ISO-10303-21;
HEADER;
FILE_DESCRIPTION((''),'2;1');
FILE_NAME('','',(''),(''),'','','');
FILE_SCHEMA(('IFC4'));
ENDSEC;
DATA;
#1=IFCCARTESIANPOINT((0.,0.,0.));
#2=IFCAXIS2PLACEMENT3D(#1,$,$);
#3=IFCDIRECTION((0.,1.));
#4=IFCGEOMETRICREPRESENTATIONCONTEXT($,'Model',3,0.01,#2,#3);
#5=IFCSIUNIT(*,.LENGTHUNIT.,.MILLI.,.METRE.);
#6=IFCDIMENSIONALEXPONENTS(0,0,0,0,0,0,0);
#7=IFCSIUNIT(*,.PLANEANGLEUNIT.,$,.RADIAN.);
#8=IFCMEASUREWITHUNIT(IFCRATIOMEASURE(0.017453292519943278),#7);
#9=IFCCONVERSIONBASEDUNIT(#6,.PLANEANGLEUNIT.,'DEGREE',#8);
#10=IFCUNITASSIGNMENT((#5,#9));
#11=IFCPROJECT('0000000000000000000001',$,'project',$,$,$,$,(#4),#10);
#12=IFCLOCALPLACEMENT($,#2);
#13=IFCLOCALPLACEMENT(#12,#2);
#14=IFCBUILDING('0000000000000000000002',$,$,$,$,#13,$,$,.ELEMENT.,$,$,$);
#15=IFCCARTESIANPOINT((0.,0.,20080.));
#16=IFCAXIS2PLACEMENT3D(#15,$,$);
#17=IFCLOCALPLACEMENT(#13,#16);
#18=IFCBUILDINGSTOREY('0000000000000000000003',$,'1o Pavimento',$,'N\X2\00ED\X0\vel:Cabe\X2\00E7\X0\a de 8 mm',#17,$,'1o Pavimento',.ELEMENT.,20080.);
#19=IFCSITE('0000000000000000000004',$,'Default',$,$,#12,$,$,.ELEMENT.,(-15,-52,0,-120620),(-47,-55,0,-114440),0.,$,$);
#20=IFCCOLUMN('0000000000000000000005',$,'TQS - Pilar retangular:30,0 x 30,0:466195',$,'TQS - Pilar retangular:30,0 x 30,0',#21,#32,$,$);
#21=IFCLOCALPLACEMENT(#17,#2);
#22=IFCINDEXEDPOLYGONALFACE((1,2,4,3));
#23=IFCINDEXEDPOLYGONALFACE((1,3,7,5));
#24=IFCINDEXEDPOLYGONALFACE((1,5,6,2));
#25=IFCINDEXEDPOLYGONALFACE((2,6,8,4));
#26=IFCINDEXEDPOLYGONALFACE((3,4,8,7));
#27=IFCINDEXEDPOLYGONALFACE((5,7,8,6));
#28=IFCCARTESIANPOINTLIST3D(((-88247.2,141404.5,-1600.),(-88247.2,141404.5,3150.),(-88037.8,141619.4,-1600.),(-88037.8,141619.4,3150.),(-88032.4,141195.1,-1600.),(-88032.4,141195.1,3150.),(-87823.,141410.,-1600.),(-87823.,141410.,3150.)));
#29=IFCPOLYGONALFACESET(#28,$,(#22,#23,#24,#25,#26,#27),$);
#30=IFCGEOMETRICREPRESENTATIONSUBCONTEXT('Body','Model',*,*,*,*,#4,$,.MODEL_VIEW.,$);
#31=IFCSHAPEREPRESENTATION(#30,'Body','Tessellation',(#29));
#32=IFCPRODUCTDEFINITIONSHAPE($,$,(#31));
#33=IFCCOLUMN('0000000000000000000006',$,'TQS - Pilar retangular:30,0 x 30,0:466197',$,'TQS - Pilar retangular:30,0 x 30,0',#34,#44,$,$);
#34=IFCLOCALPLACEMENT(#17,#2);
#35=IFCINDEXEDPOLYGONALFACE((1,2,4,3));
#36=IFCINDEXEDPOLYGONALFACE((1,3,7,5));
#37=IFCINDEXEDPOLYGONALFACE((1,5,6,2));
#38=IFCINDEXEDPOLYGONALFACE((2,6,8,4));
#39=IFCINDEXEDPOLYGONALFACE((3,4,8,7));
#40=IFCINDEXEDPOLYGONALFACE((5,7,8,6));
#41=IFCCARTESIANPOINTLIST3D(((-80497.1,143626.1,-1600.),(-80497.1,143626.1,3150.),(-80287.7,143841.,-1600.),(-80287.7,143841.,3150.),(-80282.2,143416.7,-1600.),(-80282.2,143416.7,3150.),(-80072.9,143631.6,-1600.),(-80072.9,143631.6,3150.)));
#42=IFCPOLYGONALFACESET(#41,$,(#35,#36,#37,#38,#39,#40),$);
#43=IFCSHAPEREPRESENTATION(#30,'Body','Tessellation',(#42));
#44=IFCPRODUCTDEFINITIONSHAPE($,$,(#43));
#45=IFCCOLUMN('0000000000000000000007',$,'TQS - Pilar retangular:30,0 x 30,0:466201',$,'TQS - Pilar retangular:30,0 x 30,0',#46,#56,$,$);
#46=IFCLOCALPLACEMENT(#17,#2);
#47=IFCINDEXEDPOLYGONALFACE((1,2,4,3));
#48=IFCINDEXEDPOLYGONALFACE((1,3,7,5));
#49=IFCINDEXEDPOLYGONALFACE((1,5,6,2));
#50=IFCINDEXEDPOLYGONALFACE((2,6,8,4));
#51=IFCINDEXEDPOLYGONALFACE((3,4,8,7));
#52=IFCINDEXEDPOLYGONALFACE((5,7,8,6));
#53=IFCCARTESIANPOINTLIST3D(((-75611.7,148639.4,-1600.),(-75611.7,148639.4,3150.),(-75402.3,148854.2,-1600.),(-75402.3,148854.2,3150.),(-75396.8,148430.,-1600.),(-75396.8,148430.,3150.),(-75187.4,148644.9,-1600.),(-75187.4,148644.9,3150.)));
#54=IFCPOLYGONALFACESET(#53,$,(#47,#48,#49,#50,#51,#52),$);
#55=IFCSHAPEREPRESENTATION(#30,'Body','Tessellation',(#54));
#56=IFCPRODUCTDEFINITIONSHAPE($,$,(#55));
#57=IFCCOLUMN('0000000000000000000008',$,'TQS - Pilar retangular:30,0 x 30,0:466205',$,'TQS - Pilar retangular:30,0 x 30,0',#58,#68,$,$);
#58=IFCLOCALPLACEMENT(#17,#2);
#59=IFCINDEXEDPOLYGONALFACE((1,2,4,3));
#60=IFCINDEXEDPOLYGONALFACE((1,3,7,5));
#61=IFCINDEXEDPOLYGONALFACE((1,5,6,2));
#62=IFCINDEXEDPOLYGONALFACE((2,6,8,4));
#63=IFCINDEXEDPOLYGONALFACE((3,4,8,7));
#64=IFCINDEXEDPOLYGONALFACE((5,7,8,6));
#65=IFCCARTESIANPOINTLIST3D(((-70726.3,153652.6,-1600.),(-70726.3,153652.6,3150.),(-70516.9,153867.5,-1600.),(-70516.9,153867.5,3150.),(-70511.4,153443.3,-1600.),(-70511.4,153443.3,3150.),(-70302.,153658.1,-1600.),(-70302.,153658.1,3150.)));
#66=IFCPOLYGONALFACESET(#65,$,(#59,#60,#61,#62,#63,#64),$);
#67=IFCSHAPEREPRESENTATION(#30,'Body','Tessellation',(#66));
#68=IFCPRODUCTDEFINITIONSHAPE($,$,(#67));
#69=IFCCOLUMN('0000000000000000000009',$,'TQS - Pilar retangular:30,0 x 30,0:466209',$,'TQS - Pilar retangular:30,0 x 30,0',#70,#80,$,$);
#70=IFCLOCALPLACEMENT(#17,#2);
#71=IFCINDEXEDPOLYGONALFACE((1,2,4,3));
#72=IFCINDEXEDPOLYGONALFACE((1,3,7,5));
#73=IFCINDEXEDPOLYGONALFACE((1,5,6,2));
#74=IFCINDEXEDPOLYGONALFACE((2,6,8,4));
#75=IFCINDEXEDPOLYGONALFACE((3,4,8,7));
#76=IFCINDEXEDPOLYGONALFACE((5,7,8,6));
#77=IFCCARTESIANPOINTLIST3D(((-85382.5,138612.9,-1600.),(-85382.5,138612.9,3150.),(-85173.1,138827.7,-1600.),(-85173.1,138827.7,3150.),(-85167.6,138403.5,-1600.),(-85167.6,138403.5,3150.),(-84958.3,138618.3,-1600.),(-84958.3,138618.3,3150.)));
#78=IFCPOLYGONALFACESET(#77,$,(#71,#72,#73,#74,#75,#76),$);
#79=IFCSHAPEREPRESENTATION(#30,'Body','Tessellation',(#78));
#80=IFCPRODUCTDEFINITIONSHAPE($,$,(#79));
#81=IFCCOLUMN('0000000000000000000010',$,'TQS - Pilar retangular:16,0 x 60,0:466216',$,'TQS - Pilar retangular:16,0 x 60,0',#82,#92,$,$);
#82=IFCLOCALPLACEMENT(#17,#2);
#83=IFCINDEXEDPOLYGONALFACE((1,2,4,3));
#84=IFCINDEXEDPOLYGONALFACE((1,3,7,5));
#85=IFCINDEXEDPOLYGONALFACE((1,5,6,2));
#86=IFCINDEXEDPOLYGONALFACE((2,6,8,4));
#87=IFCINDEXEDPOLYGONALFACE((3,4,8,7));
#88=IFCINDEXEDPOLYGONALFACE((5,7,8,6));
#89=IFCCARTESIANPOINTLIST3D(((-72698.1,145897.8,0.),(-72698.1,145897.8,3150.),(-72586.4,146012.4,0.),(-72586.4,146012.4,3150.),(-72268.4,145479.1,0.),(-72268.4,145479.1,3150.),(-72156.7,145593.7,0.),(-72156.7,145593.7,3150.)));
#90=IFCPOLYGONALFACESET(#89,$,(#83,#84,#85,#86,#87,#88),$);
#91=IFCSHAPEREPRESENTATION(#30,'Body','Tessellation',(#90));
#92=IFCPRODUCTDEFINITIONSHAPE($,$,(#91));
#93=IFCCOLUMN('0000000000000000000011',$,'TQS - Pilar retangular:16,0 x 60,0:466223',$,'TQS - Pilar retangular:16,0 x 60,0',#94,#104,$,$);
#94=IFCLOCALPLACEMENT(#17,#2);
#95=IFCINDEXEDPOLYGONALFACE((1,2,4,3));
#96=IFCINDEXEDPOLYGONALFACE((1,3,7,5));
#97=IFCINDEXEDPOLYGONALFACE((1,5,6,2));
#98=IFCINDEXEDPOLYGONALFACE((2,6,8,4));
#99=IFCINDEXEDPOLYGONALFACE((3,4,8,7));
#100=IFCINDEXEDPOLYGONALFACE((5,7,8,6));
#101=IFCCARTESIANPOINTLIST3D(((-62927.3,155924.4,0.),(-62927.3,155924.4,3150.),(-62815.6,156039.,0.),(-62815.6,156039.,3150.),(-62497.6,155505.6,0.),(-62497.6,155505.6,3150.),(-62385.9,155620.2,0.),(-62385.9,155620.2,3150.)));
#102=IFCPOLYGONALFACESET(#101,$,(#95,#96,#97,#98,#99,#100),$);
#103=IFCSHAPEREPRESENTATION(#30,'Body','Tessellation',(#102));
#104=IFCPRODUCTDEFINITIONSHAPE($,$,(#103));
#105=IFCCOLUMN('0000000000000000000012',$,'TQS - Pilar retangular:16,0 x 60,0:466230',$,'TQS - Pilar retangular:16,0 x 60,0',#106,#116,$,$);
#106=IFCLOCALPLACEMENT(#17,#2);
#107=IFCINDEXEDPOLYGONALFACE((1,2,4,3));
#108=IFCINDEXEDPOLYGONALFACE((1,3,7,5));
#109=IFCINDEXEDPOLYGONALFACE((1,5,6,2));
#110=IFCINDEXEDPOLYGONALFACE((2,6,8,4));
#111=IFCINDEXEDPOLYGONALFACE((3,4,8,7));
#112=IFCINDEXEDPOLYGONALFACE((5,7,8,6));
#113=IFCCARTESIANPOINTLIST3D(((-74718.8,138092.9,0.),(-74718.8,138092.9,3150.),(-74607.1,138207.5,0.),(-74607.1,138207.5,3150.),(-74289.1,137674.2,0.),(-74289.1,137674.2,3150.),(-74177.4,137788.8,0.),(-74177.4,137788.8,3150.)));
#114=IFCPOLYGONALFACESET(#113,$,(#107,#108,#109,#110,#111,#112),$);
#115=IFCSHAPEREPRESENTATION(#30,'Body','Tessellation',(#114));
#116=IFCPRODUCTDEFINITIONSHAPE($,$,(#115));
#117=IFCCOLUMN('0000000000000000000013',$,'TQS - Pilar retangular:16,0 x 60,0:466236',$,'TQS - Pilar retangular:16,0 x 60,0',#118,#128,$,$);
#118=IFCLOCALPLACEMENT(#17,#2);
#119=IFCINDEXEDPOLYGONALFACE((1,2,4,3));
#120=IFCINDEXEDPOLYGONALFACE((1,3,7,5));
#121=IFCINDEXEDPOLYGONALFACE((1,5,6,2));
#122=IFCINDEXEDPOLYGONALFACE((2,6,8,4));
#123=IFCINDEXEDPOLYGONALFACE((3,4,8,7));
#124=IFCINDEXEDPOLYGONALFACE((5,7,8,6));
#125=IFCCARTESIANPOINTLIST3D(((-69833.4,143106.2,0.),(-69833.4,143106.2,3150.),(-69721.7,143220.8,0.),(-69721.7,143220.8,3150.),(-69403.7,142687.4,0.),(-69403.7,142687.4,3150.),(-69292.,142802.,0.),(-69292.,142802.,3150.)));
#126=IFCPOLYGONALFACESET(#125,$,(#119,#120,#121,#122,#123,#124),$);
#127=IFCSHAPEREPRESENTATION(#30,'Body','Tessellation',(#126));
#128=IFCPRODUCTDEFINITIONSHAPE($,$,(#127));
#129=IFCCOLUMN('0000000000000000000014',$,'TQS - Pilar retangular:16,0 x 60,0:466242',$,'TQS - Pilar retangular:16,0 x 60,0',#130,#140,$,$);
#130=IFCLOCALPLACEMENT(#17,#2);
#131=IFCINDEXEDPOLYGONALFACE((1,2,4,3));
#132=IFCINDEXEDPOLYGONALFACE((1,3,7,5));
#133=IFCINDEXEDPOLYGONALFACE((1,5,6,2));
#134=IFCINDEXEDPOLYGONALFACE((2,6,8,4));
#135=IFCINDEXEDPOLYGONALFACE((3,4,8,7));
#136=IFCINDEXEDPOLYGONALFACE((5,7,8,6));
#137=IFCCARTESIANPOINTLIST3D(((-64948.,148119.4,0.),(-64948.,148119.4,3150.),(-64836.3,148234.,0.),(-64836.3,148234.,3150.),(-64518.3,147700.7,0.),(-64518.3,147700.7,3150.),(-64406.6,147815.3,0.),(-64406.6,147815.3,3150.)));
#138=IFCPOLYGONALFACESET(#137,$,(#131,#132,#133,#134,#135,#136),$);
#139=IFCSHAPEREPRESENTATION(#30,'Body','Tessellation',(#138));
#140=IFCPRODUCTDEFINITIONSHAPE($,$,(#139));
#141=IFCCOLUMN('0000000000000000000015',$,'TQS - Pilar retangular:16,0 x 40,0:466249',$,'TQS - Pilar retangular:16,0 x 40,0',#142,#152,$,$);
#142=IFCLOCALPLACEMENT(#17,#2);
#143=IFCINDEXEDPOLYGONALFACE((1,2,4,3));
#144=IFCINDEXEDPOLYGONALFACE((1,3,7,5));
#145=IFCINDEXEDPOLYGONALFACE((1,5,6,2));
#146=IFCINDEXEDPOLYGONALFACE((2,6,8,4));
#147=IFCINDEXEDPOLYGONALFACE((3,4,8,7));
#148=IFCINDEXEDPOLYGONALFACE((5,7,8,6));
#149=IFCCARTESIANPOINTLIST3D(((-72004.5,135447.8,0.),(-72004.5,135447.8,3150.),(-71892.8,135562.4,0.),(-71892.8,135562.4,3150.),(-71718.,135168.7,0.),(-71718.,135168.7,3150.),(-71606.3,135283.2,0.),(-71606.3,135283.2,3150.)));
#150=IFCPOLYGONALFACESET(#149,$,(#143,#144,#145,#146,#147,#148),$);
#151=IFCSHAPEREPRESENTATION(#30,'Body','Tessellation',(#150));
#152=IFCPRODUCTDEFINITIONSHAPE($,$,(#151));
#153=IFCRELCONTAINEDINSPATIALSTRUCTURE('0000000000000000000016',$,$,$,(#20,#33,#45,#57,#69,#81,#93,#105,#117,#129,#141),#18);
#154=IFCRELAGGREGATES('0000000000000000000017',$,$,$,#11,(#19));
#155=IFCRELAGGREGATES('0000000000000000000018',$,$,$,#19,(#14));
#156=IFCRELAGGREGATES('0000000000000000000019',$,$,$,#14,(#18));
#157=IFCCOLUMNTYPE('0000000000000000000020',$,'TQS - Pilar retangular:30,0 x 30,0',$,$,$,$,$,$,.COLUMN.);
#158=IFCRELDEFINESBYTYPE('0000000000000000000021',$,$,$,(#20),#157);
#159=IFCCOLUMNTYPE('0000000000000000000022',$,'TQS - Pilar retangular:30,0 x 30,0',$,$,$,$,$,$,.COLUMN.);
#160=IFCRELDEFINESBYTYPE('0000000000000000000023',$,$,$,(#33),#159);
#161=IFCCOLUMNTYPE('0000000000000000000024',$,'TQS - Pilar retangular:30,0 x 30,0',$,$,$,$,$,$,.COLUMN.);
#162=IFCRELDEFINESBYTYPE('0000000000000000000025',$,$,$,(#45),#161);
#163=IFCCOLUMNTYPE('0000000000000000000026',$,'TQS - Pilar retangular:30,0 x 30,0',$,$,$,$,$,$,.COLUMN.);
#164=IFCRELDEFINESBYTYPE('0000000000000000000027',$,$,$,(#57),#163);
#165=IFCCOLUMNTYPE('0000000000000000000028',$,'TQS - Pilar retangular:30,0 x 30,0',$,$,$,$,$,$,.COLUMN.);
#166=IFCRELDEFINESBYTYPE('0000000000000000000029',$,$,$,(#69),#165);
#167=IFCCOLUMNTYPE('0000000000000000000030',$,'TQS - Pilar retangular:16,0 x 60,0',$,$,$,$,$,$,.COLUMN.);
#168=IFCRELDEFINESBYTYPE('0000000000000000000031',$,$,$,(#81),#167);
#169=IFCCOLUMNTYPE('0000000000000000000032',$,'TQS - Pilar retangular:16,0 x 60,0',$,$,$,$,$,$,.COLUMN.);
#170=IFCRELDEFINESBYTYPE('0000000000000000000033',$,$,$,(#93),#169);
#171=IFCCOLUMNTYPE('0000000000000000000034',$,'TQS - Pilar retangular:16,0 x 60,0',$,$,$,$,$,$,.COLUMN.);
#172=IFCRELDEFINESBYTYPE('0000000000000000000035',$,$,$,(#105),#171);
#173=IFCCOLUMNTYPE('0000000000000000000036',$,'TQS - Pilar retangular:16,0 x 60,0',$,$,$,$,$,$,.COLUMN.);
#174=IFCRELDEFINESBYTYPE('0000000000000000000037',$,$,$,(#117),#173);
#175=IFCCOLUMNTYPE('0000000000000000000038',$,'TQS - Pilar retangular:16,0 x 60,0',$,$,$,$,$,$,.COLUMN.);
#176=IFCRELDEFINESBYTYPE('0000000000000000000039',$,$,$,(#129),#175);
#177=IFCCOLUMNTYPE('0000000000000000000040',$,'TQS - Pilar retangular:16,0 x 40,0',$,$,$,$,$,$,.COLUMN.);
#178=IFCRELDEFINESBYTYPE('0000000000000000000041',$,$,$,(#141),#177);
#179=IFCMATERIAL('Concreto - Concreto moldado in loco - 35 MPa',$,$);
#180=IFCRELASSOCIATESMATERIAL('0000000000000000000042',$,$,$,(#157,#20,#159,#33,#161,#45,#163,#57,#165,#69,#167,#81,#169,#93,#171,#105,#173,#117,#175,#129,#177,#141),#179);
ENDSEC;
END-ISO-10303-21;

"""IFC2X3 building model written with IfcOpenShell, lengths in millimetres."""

from ifc_helpers import new_model, entity, si_unit, converted_unit, direction, frame, frame_2d, origin, origin_2d_with_axis, place, context, subcontext, project, spatial, rectangle, extrude, source, transform, mapped, material, type_object, type_shapes, element, save


model = new_model("IFC2X3")

# Units and contexts
model_context = context("Model", 3, precision=0.01, world=origin(), true_north=direction((0.0, 1.0)))
body_context = subcontext(model_context, "Body", "Model", "MODEL_VIEW")
ifc_project = project(units=[si_unit("LENGTHUNIT", "METRE", prefix="MILLI"), converted_unit("PLANEANGLEUNIT", "DEGREE", entity("IfcRatioMeasure", 0.017453292519943278), si_unit("PLANEANGLEUNIT", "RADIAN"), dimensions=[0, 0, 0, 0, 0, 0, 0])], contexts=[model_context])

# Site, building, storey
site_placement = place(None, origin())
site = spatial("IfcSite", under=ifc_project, at=site_placement, Name="Default", CompositionType="ELEMENT", RefLatitude=(-15, -52, 0, -120620), RefLongitude=(-47, -55, 0, -114440), RefElevation=0.0)
building_placement = place(site_placement, origin())
building = spatial("IfcBuilding", under=site, at=building_placement, CompositionType="ELEMENT")
storey_placement = place(building_placement, frame((0.0, 0.0, 20080.0)))
storey = spatial("IfcBuildingStorey", under=building, at=storey_placement, Name="1o Pavimento", ObjectType="Nível:Cabeça de 8 mm", LongName="1o Pavimento", CompositionType="ELEMENT", Elevation=20080.0)

# Columns
ifc_material = material(Name="Concreto - Concreto moldado in loco - 35 MPa")
column_type_1 = type_object("IfcColumnType", Name="TQS - Pilar retangular:30,0 x 30,0", PredefinedType="COLUMN", material=ifc_material)
shared_shape_1 = source(origin(), body_context, "Body", "SweptSolid", [
    extrude(rectangle(XDim=300.0, YDim=300.0, at=origin_2d_with_axis()), frame((-88035.1, 141407.3, 18480.0), z_axis=(0.0, 0.0, 1.0), x_axis=(-0.71618, 0.697915, 0.0)), (0.0, 0.0, 1.0), 4750.0),
])
type_shapes(column_type_1, [shared_shape_1])
column_1_placement = place(storey_placement, frame((0.0, 0.0, -20080.0)))
element("IfcColumn", 1, at=column_1_placement, inside=storey, type_object=column_type_1, material=ifc_material, Name="TQS - Pilar retangular:30,0 x 30,0:466195", ObjectType="TQS - Pilar retangular:30,0 x 30,0", context=body_context, shape_type="MappedRepresentation", body=[
    mapped(shared_shape_1, transform((0.0, 0.0, 0.0), scale=1.0)),
])
column_type_2 = type_object("IfcColumnType", Name="TQS - Pilar retangular:30,0 x 30,0", PredefinedType="COLUMN", material=ifc_material)
shared_shape_2 = source(origin(), body_context, "Body", "SweptSolid", [
    extrude(rectangle(XDim=300.0, YDim=300.0, at=origin_2d_with_axis()), frame((-80285.0, 143628.9, 18480.0), z_axis=(0.0, 0.0, 1.0), x_axis=(-0.71618, 0.697915, 0.0)), (0.0, 0.0, 1.0), 4750.0),
])
type_shapes(column_type_2, [shared_shape_2])
column_2_placement = place(storey_placement, frame((0.0, 0.0, -20080.0)))
element("IfcColumn", 2, at=column_2_placement, inside=storey, type_object=column_type_2, material=ifc_material, Name="TQS - Pilar retangular:30,0 x 30,0:466197", ObjectType="TQS - Pilar retangular:30,0 x 30,0", context=body_context, shape_type="MappedRepresentation", body=[
    mapped(shared_shape_2, transform((0.0, 0.0, 0.0), scale=1.0)),
])
column_type_3 = type_object("IfcColumnType", Name="TQS - Pilar retangular:30,0 x 30,0", PredefinedType="COLUMN", material=ifc_material)
shared_shape_3 = source(origin(), body_context, "Body", "SweptSolid", [
    extrude(rectangle(XDim=300.0, YDim=300.0, at=origin_2d_with_axis()), frame((-75399.6, 148642.1, 18480.0), z_axis=(0.0, 0.0, 1.0), x_axis=(-0.71618, 0.697915, 0.0)), (0.0, 0.0, 1.0), 4750.0),
])
type_shapes(column_type_3, [shared_shape_3])
column_3_placement = place(storey_placement, frame((0.0, 0.0, -20080.0)))
element("IfcColumn", 3, at=column_3_placement, inside=storey, type_object=column_type_3, material=ifc_material, Name="TQS - Pilar retangular:30,0 x 30,0:466201", ObjectType="TQS - Pilar retangular:30,0 x 30,0", context=body_context, shape_type="MappedRepresentation", body=[
    mapped(shared_shape_3, transform((0.0, 0.0, 0.0), scale=1.0)),
])
column_type_4 = type_object("IfcColumnType", Name="TQS - Pilar retangular:30,0 x 30,0", PredefinedType="COLUMN", material=ifc_material)
shared_shape_4 = source(origin(), body_context, "Body", "SweptSolid", [
    extrude(rectangle(XDim=300.0, YDim=300.0, at=origin_2d_with_axis()), frame((-70514.2, 153655.4, 18480.0), z_axis=(0.0, 0.0, 1.0), x_axis=(-0.71618, 0.697915, 0.0)), (0.0, 0.0, 1.0), 4750.0),
])
type_shapes(column_type_4, [shared_shape_4])
column_4_placement = place(storey_placement, frame((0.0, 0.0, -20080.0)))
element("IfcColumn", 4, at=column_4_placement, inside=storey, type_object=column_type_4, material=ifc_material, Name="TQS - Pilar retangular:30,0 x 30,0:466205", ObjectType="TQS - Pilar retangular:30,0 x 30,0", context=body_context, shape_type="MappedRepresentation", body=[
    mapped(shared_shape_4, transform((0.0, 0.0, 0.0), scale=1.0)),
])
column_type_5 = type_object("IfcColumnType", Name="TQS - Pilar retangular:30,0 x 30,0", PredefinedType="COLUMN", material=ifc_material)
shared_shape_5 = source(origin(), body_context, "Body", "SweptSolid", [
    extrude(rectangle(XDim=300.0, YDim=300.0, at=origin_2d_with_axis()), frame((-85170.4, 138615.6, 18480.0), z_axis=(0.0, 0.0, 1.0), x_axis=(-0.71618, 0.697915, 0.0)), (0.0, 0.0, 1.0), 4750.0),
])
type_shapes(column_type_5, [shared_shape_5])
column_5_placement = place(storey_placement, frame((0.0, 0.0, -20080.0)))
element("IfcColumn", 5, at=column_5_placement, inside=storey, type_object=column_type_5, material=ifc_material, Name="TQS - Pilar retangular:30,0 x 30,0:466209", ObjectType="TQS - Pilar retangular:30,0 x 30,0", context=body_context, shape_type="MappedRepresentation", body=[
    mapped(shared_shape_5, transform((0.0, 0.0, 0.0), scale=1.0)),
])
column_type_6 = type_object("IfcColumnType", Name="TQS - Pilar retangular:16,0 x 60,0", PredefinedType="COLUMN", material=ifc_material)
shared_shape_6 = source(origin(), body_context, "Body", "SweptSolid", [
    extrude(rectangle(XDim=600.0, YDim=160.0, at=frame_2d((0.0, 0.0), x_axis=(1.0, 0.0))), frame((-72427.4, 145745.8, 20080.0), z_axis=(0.0, 0.0, 1.0), x_axis=(-0.71618, 0.697915, 0.0)), (0.0, 0.0, 1.0), 3150.0),
])
type_shapes(column_type_6, [shared_shape_6])
column_6_placement = place(storey_placement, frame((0.0, 0.0, -20080.0)))
element("IfcColumn", 6, at=column_6_placement, inside=storey, type_object=column_type_6, material=ifc_material, Name="TQS - Pilar retangular:16,0 x 60,0:466216", ObjectType="TQS - Pilar retangular:16,0 x 60,0", context=body_context, shape_type="MappedRepresentation", body=[
    mapped(shared_shape_6, transform((0.0, 0.0, 0.0), scale=1.0)),
])
column_type_7 = type_object("IfcColumnType", Name="TQS - Pilar retangular:16,0 x 60,0", PredefinedType="COLUMN", material=ifc_material)
shared_shape_7 = source(origin(), body_context, "Body", "SweptSolid", [
    extrude(rectangle(XDim=600.0, YDim=160.0, at=frame_2d((0.0, 0.0), x_axis=(1.0, 0.0))), frame((-62656.6, 155772.3, 20080.0), z_axis=(0.0, 0.0, 1.0), x_axis=(-0.71618, 0.697915, 0.0)), (0.0, 0.0, 1.0), 3150.0),
])
type_shapes(column_type_7, [shared_shape_7])
column_7_placement = place(storey_placement, frame((0.0, 0.0, -20080.0)))
element("IfcColumn", 7, at=column_7_placement, inside=storey, type_object=column_type_7, material=ifc_material, Name="TQS - Pilar retangular:16,0 x 60,0:466223", ObjectType="TQS - Pilar retangular:16,0 x 60,0", context=body_context, shape_type="MappedRepresentation", body=[
    mapped(shared_shape_7, transform((0.0, 0.0, 0.0), scale=1.0)),
])
column_type_8 = type_object("IfcColumnType", Name="TQS - Pilar retangular:16,0 x 60,0", PredefinedType="COLUMN", material=ifc_material)
shared_shape_8 = source(origin(), body_context, "Body", "SweptSolid", [
    extrude(rectangle(XDim=600.0, YDim=160.0, at=frame_2d((0.0, 0.0), x_axis=(1.0, 0.0))), frame((-74448.1, 137940.8, 20080.0), z_axis=(0.0, 0.0, 1.0), x_axis=(-0.71618, 0.697915, 0.0)), (0.0, 0.0, 1.0), 3150.0),
])
type_shapes(column_type_8, [shared_shape_8])
column_8_placement = place(storey_placement, frame((0.0, 0.0, -20080.0)))
element("IfcColumn", 8, at=column_8_placement, inside=storey, type_object=column_type_8, material=ifc_material, Name="TQS - Pilar retangular:16,0 x 60,0:466230", ObjectType="TQS - Pilar retangular:16,0 x 60,0", context=body_context, shape_type="MappedRepresentation", body=[
    mapped(shared_shape_8, transform((0.0, 0.0, 0.0), scale=1.0)),
])
column_type_9 = type_object("IfcColumnType", Name="TQS - Pilar retangular:16,0 x 60,0", PredefinedType="COLUMN", material=ifc_material)
shared_shape_9 = source(origin(), body_context, "Body", "SweptSolid", [
    extrude(rectangle(XDim=600.0, YDim=160.0, at=frame_2d((0.0, 0.0), x_axis=(1.0, 0.0))), frame((-69562.7, 142954.1, 20080.0), z_axis=(0.0, 0.0, 1.0), x_axis=(-0.71618, 0.697915, 0.0)), (0.0, 0.0, 1.0), 3150.0),
])
type_shapes(column_type_9, [shared_shape_9])
column_9_placement = place(storey_placement, frame((0.0, 0.0, -20080.0)))
element("IfcColumn", 9, at=column_9_placement, inside=storey, type_object=column_type_9, material=ifc_material, Name="TQS - Pilar retangular:16,0 x 60,0:466236", ObjectType="TQS - Pilar retangular:16,0 x 60,0", context=body_context, shape_type="MappedRepresentation", body=[
    mapped(shared_shape_9, transform((0.0, 0.0, 0.0), scale=1.0)),
])
column_type_10 = type_object("IfcColumnType", Name="TQS - Pilar retangular:16,0 x 60,0", PredefinedType="COLUMN", material=ifc_material)
shared_shape_10 = source(origin(), body_context, "Body", "SweptSolid", [
    extrude(rectangle(XDim=600.0, YDim=160.0, at=frame_2d((0.0, 0.0), x_axis=(1.0, 0.0))), frame((-64677.3, 147967.4, 20080.0), z_axis=(0.0, 0.0, 1.0), x_axis=(-0.71618, 0.697915, 0.0)), (0.0, 0.0, 1.0), 3150.0),
])
type_shapes(column_type_10, [shared_shape_10])
column_10_placement = place(storey_placement, frame((0.0, 0.0, -20080.0)))
element("IfcColumn", 10, at=column_10_placement, inside=storey, type_object=column_type_10, material=ifc_material, Name="TQS - Pilar retangular:16,0 x 60,0:466242", ObjectType="TQS - Pilar retangular:16,0 x 60,0", context=body_context, shape_type="MappedRepresentation", body=[
    mapped(shared_shape_10, transform((0.0, 0.0, 0.0), scale=1.0)),
])
column_type_11 = type_object("IfcColumnType", Name="TQS - Pilar retangular:16,0 x 40,0", PredefinedType="COLUMN", material=ifc_material)
shared_shape_11 = source(origin(), body_context, "Body", "SweptSolid", [
    extrude(rectangle(XDim=400.0, YDim=160.0, at=frame_2d((0.0, 0.0), x_axis=(1.0, 0.0))), frame((-71805.4, 135365.5, 20080.0), z_axis=(0.0, 0.0, 1.0), x_axis=(-0.71618, 0.697915, 0.0)), (0.0, 0.0, 1.0), 3150.0),
])
type_shapes(column_type_11, [shared_shape_11])
column_11_placement = place(storey_placement, frame((0.0, 0.0, -20080.0)))
element("IfcColumn", 11, at=column_11_placement, inside=storey, type_object=column_type_11, material=ifc_material, Name="TQS - Pilar retangular:16,0 x 40,0:466249", ObjectType="TQS - Pilar retangular:16,0 x 40,0", context=body_context, shape_type="MappedRepresentation", body=[
    mapped(shared_shape_11, transform((0.0, 0.0, 0.0), scale=1.0)),
])

save(model, "model.ifc")
